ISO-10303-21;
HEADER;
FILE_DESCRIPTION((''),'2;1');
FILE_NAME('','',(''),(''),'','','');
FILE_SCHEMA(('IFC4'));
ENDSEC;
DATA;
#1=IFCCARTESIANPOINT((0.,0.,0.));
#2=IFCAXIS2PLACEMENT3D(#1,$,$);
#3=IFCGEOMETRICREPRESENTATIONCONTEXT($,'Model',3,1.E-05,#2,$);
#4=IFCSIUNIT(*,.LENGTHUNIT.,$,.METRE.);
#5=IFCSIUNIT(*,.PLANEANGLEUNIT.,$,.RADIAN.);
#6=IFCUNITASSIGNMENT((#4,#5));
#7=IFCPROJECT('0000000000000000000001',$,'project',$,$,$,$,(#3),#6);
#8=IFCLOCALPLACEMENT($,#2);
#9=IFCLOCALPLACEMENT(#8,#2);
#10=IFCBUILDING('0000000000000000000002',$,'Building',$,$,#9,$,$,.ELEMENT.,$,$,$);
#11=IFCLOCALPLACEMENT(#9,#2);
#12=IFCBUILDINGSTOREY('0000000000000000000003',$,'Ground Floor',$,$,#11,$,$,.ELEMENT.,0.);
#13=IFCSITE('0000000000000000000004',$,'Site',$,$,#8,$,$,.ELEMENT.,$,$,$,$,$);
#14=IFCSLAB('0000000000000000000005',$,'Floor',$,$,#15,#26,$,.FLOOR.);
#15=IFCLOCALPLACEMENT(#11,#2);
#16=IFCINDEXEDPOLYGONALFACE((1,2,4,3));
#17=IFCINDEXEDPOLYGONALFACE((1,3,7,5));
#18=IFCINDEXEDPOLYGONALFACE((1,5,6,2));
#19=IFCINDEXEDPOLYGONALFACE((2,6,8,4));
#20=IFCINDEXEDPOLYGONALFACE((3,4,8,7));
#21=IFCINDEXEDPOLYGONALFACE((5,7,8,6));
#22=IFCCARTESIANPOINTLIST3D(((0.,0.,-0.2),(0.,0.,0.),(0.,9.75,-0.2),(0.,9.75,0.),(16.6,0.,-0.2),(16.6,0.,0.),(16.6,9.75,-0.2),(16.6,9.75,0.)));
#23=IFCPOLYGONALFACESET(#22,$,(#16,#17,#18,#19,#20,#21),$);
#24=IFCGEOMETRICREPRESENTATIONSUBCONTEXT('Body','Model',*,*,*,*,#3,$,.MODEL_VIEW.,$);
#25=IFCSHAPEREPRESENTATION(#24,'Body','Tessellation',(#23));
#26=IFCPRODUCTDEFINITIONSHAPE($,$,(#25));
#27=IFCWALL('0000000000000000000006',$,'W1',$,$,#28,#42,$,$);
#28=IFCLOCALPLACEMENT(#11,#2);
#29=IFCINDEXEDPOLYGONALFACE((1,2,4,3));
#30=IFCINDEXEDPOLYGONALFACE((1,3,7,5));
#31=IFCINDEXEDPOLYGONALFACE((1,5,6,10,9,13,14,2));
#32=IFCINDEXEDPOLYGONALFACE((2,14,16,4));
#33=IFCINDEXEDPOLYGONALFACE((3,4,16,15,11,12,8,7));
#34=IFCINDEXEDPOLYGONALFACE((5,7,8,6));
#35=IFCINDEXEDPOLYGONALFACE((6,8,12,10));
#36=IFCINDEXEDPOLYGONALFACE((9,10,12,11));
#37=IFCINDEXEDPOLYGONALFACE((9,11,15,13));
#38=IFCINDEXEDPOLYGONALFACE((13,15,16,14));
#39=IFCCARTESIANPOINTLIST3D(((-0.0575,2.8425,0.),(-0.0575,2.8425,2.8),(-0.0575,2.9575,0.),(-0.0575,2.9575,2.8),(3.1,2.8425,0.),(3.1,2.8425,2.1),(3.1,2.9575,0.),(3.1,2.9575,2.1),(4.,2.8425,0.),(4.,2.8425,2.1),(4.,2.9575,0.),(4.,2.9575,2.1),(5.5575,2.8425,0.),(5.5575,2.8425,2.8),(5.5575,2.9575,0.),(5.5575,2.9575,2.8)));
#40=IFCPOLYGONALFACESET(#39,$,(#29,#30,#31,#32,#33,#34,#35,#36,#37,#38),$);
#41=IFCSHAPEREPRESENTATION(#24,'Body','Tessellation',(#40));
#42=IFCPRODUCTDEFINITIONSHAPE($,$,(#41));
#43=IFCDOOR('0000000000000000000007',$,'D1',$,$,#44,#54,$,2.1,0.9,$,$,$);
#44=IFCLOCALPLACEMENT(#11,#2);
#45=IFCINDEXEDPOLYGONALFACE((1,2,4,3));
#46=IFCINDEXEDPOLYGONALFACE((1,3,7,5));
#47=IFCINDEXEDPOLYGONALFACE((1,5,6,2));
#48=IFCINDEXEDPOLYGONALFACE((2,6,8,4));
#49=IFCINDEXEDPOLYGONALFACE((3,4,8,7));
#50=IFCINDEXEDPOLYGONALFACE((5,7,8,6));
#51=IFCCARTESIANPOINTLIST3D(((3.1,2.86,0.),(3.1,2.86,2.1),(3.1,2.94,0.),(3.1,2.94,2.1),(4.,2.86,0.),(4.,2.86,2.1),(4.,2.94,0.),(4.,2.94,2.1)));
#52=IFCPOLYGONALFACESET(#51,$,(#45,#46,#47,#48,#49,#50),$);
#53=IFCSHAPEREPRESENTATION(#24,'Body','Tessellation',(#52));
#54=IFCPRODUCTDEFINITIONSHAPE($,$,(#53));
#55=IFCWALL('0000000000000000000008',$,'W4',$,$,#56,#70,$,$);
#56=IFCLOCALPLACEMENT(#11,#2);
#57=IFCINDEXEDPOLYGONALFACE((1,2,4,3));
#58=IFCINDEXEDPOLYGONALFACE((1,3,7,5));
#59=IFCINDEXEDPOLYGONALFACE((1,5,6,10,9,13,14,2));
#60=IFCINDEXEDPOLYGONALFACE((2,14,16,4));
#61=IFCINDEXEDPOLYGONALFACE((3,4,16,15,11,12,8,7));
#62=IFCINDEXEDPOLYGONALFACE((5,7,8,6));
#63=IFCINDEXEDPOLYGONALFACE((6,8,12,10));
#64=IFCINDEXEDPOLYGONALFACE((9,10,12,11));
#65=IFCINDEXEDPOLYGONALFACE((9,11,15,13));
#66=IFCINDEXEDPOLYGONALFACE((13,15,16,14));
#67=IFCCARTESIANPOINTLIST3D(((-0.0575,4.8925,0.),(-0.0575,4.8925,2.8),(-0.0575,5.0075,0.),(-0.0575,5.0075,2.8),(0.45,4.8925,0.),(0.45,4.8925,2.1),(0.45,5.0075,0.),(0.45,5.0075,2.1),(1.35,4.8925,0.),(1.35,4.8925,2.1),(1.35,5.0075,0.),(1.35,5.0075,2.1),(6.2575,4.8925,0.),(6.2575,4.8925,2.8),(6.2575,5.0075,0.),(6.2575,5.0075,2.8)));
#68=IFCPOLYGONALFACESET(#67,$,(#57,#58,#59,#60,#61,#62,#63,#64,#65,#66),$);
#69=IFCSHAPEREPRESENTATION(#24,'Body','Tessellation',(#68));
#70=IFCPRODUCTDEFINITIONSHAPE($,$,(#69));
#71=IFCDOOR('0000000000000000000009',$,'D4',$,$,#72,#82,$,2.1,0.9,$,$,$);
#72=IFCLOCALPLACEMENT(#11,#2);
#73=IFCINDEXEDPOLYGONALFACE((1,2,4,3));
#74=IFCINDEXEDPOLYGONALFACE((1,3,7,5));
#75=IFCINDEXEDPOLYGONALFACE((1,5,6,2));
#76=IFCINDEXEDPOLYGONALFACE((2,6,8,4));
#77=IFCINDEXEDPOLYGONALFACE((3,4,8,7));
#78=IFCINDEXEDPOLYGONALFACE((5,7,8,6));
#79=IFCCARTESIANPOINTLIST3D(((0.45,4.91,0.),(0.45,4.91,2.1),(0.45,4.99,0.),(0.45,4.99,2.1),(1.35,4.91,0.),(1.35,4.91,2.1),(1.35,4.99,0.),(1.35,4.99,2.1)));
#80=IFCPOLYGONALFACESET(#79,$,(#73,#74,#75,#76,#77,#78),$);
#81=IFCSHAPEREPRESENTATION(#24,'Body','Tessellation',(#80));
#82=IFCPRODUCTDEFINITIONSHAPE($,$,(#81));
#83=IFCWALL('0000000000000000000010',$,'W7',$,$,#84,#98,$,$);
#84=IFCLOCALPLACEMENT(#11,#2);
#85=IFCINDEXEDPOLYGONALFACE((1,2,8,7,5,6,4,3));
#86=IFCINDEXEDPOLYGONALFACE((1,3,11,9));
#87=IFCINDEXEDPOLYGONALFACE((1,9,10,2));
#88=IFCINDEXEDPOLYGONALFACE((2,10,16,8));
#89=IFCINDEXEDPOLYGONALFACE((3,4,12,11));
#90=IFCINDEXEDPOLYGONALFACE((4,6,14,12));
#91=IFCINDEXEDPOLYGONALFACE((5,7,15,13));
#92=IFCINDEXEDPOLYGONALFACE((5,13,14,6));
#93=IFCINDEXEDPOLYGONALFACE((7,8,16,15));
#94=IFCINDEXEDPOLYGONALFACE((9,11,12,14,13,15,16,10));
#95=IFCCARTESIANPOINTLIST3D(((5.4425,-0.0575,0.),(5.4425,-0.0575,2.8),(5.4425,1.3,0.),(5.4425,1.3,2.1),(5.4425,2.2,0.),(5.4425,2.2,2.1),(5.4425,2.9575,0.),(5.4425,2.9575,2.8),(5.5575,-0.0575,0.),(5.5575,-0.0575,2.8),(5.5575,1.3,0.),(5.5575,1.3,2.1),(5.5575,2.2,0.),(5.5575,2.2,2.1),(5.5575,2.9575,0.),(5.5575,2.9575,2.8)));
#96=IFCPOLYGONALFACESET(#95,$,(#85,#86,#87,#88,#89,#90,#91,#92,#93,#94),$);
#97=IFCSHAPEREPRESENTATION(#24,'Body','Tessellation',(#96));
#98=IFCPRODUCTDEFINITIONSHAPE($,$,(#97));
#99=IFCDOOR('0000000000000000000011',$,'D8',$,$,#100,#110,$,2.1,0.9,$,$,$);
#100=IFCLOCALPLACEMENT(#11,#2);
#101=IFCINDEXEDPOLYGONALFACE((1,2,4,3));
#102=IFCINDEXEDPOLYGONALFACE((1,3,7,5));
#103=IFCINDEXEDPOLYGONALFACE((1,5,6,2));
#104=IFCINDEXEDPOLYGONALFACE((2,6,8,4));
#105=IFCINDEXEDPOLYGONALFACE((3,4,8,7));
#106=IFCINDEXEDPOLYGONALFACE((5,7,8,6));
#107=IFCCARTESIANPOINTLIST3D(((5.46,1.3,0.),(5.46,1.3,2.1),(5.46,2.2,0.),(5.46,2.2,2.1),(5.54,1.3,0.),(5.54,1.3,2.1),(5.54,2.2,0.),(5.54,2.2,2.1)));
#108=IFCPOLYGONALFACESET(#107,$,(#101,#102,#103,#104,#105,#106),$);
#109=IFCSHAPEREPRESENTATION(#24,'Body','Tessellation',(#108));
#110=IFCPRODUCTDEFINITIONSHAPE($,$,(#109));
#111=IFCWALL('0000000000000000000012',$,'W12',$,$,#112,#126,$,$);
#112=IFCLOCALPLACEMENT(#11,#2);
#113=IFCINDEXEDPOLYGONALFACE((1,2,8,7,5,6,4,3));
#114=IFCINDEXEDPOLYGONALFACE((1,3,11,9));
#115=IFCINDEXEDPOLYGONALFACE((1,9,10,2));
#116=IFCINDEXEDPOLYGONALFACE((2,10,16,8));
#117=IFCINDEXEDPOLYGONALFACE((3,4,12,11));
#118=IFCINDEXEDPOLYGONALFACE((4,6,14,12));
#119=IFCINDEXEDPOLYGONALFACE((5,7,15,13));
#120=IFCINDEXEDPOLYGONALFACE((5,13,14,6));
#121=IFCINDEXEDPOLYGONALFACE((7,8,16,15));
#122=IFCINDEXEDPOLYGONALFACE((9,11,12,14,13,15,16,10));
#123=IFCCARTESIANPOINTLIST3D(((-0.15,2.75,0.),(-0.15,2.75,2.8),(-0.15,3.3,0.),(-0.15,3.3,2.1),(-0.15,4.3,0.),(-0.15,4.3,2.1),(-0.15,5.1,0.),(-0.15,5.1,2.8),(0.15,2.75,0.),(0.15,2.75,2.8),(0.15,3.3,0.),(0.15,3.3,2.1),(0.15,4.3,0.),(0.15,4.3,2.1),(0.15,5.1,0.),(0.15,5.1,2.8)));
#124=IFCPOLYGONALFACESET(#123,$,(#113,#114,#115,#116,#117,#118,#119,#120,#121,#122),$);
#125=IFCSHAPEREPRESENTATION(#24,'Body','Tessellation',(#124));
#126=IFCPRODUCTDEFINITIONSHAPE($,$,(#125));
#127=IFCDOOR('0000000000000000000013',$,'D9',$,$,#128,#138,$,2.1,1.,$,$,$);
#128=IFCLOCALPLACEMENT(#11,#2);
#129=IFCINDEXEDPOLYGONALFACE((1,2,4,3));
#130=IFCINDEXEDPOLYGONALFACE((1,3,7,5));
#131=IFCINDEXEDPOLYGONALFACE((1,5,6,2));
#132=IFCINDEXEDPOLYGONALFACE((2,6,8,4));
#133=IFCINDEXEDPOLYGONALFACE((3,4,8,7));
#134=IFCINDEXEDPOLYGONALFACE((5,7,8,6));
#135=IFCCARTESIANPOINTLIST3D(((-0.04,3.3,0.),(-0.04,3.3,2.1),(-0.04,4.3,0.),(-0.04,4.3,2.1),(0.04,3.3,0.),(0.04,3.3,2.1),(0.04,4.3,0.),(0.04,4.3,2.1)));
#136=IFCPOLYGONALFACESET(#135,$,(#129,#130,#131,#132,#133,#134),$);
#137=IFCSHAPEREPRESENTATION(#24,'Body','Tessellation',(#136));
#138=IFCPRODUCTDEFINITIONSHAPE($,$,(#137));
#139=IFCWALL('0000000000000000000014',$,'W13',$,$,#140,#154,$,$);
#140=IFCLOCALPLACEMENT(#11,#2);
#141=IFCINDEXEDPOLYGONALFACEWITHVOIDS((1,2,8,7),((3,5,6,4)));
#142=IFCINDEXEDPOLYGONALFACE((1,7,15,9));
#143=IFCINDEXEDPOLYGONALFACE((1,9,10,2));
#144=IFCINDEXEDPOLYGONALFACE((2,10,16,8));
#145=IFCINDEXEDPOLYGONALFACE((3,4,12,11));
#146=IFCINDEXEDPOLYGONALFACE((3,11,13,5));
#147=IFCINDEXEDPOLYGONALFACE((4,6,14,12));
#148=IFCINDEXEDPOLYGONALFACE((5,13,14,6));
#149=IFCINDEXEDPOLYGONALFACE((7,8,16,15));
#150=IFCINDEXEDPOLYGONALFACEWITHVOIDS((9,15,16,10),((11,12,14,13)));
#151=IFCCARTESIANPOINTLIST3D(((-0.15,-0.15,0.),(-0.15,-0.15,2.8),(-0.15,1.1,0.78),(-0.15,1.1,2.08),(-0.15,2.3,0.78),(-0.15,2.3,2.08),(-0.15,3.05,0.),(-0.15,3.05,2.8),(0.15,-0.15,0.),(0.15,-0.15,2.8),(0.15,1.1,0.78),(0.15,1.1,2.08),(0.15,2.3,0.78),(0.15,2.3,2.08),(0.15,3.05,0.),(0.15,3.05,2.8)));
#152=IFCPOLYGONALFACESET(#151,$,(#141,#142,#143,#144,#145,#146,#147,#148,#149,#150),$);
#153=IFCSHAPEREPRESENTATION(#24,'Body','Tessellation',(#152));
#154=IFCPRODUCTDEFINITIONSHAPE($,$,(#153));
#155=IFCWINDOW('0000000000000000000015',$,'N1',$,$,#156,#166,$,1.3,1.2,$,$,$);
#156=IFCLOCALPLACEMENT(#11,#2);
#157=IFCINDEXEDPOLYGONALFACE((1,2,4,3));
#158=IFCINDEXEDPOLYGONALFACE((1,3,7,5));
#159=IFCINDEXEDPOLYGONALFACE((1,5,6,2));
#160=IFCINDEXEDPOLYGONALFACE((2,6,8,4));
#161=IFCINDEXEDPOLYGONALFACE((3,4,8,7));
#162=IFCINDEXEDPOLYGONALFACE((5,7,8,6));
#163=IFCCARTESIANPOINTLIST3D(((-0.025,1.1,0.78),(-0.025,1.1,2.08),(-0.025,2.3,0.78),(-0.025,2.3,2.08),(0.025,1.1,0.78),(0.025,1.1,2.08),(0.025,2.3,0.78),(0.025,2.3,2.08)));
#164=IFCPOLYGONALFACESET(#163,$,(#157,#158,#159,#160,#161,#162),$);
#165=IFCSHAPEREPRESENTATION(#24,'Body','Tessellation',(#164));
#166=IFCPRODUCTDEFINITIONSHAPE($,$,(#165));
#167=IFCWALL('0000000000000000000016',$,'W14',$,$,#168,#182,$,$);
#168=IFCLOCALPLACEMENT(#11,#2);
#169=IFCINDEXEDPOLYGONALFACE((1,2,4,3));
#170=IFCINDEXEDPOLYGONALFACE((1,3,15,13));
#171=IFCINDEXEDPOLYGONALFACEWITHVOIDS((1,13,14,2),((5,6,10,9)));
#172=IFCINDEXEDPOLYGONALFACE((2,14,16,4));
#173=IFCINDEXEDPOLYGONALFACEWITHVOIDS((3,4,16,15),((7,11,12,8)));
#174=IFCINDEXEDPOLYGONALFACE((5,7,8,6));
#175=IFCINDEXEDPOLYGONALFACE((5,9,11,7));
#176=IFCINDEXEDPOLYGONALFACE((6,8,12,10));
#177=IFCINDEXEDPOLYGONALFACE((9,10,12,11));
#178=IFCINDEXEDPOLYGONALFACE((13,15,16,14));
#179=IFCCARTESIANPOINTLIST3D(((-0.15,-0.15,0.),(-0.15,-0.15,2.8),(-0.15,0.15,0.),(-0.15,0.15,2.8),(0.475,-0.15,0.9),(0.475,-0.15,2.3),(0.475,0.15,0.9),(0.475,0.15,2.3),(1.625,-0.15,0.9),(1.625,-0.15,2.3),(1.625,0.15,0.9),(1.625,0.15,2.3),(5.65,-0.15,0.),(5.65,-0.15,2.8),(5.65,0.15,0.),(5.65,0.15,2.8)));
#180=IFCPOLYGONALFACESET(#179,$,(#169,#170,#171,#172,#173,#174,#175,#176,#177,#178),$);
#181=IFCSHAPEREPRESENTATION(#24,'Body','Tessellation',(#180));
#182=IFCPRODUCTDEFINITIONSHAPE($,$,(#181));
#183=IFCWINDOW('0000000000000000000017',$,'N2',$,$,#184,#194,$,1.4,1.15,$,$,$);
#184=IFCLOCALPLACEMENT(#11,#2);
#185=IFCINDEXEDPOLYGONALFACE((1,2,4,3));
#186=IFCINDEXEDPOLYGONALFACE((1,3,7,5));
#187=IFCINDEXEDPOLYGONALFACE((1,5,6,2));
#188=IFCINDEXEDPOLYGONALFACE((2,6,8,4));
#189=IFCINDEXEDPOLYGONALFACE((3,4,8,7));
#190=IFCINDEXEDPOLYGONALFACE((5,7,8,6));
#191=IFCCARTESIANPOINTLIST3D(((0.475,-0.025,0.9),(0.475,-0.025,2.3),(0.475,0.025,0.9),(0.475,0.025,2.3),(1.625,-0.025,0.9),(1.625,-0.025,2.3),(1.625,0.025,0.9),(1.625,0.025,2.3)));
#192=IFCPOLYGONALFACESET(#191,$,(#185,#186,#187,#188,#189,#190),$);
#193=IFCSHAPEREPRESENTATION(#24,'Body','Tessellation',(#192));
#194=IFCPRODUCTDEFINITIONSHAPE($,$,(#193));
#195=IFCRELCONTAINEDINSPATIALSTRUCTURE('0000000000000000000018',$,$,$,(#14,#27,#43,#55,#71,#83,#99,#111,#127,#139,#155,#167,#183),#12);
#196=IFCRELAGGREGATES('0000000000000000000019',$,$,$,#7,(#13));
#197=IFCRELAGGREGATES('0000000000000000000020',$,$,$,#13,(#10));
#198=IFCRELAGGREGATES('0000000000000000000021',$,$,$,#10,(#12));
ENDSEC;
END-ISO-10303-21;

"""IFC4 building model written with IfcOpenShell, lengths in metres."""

from ifc_helpers import new_model, si_unit, frame, frame_2d, origin, origin_2d, place, context, subcontext, project, spatial, polyline, rectangle, outline, extrude, element, fill, save


model = new_model("IFC4")

# Units and contexts
model_context = context("Model", 3, precision=1e-05, world=origin())
body_context = subcontext(model_context, "Body", "Model", "MODEL_VIEW")
ifc_project = project(units=[si_unit("LENGTHUNIT", "METRE"), si_unit("PLANEANGLEUNIT", "RADIAN")], contexts=[model_context])

# Site, building, storey
site_placement = place(None, origin())
site = spatial("IfcSite", under=ifc_project, at=site_placement, Name="Site", CompositionType="ELEMENT")
building_placement = place(site_placement, origin())
building = spatial("IfcBuilding", under=site, at=building_placement, Name="Building", CompositionType="ELEMENT")
storey_placement = place(building_placement, origin())
storey = spatial("IfcBuildingStorey", under=building, at=storey_placement, Name="Ground Floor", CompositionType="ELEMENT", Elevation=0.0)

# Slab
slab_placement = place(storey_placement, origin())
element("IfcSlab", 1, at=slab_placement, inside=storey, Name="Floor", PredefinedType="FLOOR", context=body_context, shape_type="SweptSolid", body=[
    extrude(outline(polyline([(0.0, 0.0), (16.6, 0.0), (16.6, 9.75), (0.0, 9.75), (0.0, 0.0)])), origin(), (0.0, 0.0, -1.0), 0.2),
])

# Walls, openings, doors
wall_1_placement = place(storey_placement, frame((0.0, 2.9, 0.0), x_axis=(1.0, 0.0, 0.0)))
wall_1 = element("IfcWall", 2, at=wall_1_placement, inside=storey, Name="W1", context=body_context, shape_type="SweptSolid", body=[
    extrude(rectangle(XDim=5.615, YDim=0.115, at=frame_2d((2.75, 0.0))), origin(), (0.0, 0.0, 1.0), 2.8),
])
opening_1_placement = place(wall_1_placement, frame((3.55, 0.0, 0.0)))
opening_1 = element("IfcOpeningElement", 3, at=opening_1_placement, cuts=wall_1, context=body_context, shape_type="SweptSolid", body=[
    extrude(rectangle(XDim=0.9, YDim=0.215, at=origin_2d()), origin(), (0.0, 0.0, 1.0), 2.1),
])
door_1_placement = place(opening_1_placement, origin())
door_1 = element("IfcDoor", 4, at=door_1_placement, inside=storey, Name="D1", OverallHeight=2.1, OverallWidth=0.9, context=body_context, shape_type="SweptSolid", body=[
    extrude(rectangle(XDim=0.9, YDim=0.08, at=origin_2d()), origin(), (0.0, 0.0, 1.0), 2.1),
])
fill(opening_1, door_1)
wall_2_placement = place(storey_placement, frame((0.0, 4.95, 0.0), x_axis=(1.0, 0.0, 0.0)))
wall_2 = element("IfcWall", 5, at=wall_2_placement, inside=storey, Name="W4", context=body_context, shape_type="SweptSolid", body=[
    extrude(rectangle(XDim=6.315, YDim=0.115, at=frame_2d((3.1, 0.0))), origin(), (0.0, 0.0, 1.0), 2.8),
])
opening_2_placement = place(wall_2_placement, frame((0.9, 0.0, 0.0)))
opening_2 = element("IfcOpeningElement", 6, at=opening_2_placement, cuts=wall_2, context=body_context, shape_type="SweptSolid", body=[
    extrude(rectangle(XDim=0.9, YDim=0.215, at=origin_2d()), origin(), (0.0, 0.0, 1.0), 2.1),
])
door_2_placement = place(opening_2_placement, origin())
door_2 = element("IfcDoor", 7, at=door_2_placement, inside=storey, Name="D4", OverallHeight=2.1, OverallWidth=0.9, context=body_context, shape_type="SweptSolid", body=[
    extrude(rectangle(XDim=0.9, YDim=0.08, at=origin_2d()), origin(), (0.0, 0.0, 1.0), 2.1),
])
fill(opening_2, door_2)
wall_3_placement = place(storey_placement, frame((5.5, 0.0, 0.0), x_axis=(0.0, 1.0, 0.0)))
wall_3 = element("IfcWall", 8, at=wall_3_placement, inside=storey, Name="W7", context=body_context, shape_type="SweptSolid", body=[
    extrude(rectangle(XDim=3.015, YDim=0.115, at=frame_2d((1.45, 0.0))), origin(), (0.0, 0.0, 1.0), 2.8),
])
opening_3_placement = place(wall_3_placement, frame((1.75, 0.0, 0.0)))
opening_3 = element("IfcOpeningElement", 9, at=opening_3_placement, cuts=wall_3, context=body_context, shape_type="SweptSolid", body=[
    extrude(rectangle(XDim=0.9, YDim=0.215, at=origin_2d()), origin(), (0.0, 0.0, 1.0), 2.1),
])
door_3_placement = place(opening_3_placement, origin())
door_3 = element("IfcDoor", 10, at=door_3_placement, inside=storey, Name="D8", OverallHeight=2.1, OverallWidth=0.9, context=body_context, shape_type="SweptSolid", body=[
    extrude(rectangle(XDim=0.9, YDim=0.08, at=origin_2d()), origin(), (0.0, 0.0, 1.0), 2.1),
])
fill(opening_3, door_3)
wall_4_placement = place(storey_placement, frame((0.0, 2.9, 0.0), x_axis=(0.0, 1.0, 0.0)))
wall_4 = element("IfcWall", 11, at=wall_4_placement, inside=storey, Name="W12", context=body_context, shape_type="SweptSolid", body=[
    extrude(rectangle(XDim=2.35, YDim=0.3, at=frame_2d((1.025, 0.0))), origin(), (0.0, 0.0, 1.0), 2.8),
])
opening_4_placement = place(wall_4_placement, frame((0.9, 0.0, 0.0)))
opening_4 = element("IfcOpeningElement", 12, at=opening_4_placement, cuts=wall_4, context=body_context, shape_type="SweptSolid", body=[
    extrude(rectangle(XDim=1.0, YDim=0.4, at=origin_2d()), origin(), (0.0, 0.0, 1.0), 2.1),
])
door_4_placement = place(opening_4_placement, origin())
door_4 = element("IfcDoor", 13, at=door_4_placement, inside=storey, Name="D9", OverallHeight=2.1, OverallWidth=1.0, context=body_context, shape_type="SweptSolid", body=[
    extrude(rectangle(XDim=1.0, YDim=0.08, at=origin_2d()), origin(), (0.0, 0.0, 1.0), 2.1),
])
fill(opening_4, door_4)

# Walls, openings, windows
wall_5_placement = place(storey_placement, frame((0.0, 0.0, 0.0), x_axis=(0.0, 1.0, 0.0)))
wall_5 = element("IfcWall", 14, at=wall_5_placement, inside=storey, Name="W13", context=body_context, shape_type="SweptSolid", body=[
    extrude(rectangle(XDim=3.2, YDim=0.3, at=frame_2d((1.45, 0.0))), origin(), (0.0, 0.0, 1.0), 2.8),
])
opening_5_placement = place(wall_5_placement, frame((1.7, 0.0, 0.78)))
opening_5 = element("IfcOpeningElement", 15, at=opening_5_placement, cuts=wall_5, context=body_context, shape_type="SweptSolid", body=[
    extrude(rectangle(XDim=1.2, YDim=0.4, at=origin_2d()), origin(), (0.0, 0.0, 1.0), 1.3),
])
window_1_placement = place(opening_5_placement, origin())
window_1 = element("IfcWindow", 16, at=window_1_placement, inside=storey, Name="N1", OverallHeight=1.3, OverallWidth=1.2, context=body_context, shape_type="SweptSolid", body=[
    extrude(rectangle(XDim=1.2, YDim=0.05, at=origin_2d()), origin(), (0.0, 0.0, 1.0), 1.3),
])
fill(opening_5, window_1)
wall_6_placement = place(storey_placement, frame((0.0, 0.0, 0.0), x_axis=(1.0, 0.0, 0.0)))
wall_6 = element("IfcWall", 17, at=wall_6_placement, inside=storey, Name="W14", context=body_context, shape_type="SweptSolid", body=[
    extrude(rectangle(XDim=5.8, YDim=0.3, at=frame_2d((2.75, 0.0))), origin(), (0.0, 0.0, 1.0), 2.8),
])
opening_6_placement = place(wall_6_placement, frame((1.05, 0.0, 0.9)))
opening_6 = element("IfcOpeningElement", 18, at=opening_6_placement, cuts=wall_6, context=body_context, shape_type="SweptSolid", body=[
    extrude(rectangle(XDim=1.15, YDim=0.4, at=origin_2d()), origin(), (0.0, 0.0, 1.0), 1.4),
])
window_2_placement = place(opening_6_placement, origin())
window_2 = element("IfcWindow", 19, at=window_2_placement, inside=storey, Name="N2", OverallHeight=1.4, OverallWidth=1.15, context=body_context, shape_type="SweptSolid", body=[
    extrude(rectangle(XDim=1.15, YDim=0.05, at=origin_2d()), origin(), (0.0, 0.0, 1.0), 1.4),
])
fill(opening_6, window_2)

save(model, "model.ifc")
